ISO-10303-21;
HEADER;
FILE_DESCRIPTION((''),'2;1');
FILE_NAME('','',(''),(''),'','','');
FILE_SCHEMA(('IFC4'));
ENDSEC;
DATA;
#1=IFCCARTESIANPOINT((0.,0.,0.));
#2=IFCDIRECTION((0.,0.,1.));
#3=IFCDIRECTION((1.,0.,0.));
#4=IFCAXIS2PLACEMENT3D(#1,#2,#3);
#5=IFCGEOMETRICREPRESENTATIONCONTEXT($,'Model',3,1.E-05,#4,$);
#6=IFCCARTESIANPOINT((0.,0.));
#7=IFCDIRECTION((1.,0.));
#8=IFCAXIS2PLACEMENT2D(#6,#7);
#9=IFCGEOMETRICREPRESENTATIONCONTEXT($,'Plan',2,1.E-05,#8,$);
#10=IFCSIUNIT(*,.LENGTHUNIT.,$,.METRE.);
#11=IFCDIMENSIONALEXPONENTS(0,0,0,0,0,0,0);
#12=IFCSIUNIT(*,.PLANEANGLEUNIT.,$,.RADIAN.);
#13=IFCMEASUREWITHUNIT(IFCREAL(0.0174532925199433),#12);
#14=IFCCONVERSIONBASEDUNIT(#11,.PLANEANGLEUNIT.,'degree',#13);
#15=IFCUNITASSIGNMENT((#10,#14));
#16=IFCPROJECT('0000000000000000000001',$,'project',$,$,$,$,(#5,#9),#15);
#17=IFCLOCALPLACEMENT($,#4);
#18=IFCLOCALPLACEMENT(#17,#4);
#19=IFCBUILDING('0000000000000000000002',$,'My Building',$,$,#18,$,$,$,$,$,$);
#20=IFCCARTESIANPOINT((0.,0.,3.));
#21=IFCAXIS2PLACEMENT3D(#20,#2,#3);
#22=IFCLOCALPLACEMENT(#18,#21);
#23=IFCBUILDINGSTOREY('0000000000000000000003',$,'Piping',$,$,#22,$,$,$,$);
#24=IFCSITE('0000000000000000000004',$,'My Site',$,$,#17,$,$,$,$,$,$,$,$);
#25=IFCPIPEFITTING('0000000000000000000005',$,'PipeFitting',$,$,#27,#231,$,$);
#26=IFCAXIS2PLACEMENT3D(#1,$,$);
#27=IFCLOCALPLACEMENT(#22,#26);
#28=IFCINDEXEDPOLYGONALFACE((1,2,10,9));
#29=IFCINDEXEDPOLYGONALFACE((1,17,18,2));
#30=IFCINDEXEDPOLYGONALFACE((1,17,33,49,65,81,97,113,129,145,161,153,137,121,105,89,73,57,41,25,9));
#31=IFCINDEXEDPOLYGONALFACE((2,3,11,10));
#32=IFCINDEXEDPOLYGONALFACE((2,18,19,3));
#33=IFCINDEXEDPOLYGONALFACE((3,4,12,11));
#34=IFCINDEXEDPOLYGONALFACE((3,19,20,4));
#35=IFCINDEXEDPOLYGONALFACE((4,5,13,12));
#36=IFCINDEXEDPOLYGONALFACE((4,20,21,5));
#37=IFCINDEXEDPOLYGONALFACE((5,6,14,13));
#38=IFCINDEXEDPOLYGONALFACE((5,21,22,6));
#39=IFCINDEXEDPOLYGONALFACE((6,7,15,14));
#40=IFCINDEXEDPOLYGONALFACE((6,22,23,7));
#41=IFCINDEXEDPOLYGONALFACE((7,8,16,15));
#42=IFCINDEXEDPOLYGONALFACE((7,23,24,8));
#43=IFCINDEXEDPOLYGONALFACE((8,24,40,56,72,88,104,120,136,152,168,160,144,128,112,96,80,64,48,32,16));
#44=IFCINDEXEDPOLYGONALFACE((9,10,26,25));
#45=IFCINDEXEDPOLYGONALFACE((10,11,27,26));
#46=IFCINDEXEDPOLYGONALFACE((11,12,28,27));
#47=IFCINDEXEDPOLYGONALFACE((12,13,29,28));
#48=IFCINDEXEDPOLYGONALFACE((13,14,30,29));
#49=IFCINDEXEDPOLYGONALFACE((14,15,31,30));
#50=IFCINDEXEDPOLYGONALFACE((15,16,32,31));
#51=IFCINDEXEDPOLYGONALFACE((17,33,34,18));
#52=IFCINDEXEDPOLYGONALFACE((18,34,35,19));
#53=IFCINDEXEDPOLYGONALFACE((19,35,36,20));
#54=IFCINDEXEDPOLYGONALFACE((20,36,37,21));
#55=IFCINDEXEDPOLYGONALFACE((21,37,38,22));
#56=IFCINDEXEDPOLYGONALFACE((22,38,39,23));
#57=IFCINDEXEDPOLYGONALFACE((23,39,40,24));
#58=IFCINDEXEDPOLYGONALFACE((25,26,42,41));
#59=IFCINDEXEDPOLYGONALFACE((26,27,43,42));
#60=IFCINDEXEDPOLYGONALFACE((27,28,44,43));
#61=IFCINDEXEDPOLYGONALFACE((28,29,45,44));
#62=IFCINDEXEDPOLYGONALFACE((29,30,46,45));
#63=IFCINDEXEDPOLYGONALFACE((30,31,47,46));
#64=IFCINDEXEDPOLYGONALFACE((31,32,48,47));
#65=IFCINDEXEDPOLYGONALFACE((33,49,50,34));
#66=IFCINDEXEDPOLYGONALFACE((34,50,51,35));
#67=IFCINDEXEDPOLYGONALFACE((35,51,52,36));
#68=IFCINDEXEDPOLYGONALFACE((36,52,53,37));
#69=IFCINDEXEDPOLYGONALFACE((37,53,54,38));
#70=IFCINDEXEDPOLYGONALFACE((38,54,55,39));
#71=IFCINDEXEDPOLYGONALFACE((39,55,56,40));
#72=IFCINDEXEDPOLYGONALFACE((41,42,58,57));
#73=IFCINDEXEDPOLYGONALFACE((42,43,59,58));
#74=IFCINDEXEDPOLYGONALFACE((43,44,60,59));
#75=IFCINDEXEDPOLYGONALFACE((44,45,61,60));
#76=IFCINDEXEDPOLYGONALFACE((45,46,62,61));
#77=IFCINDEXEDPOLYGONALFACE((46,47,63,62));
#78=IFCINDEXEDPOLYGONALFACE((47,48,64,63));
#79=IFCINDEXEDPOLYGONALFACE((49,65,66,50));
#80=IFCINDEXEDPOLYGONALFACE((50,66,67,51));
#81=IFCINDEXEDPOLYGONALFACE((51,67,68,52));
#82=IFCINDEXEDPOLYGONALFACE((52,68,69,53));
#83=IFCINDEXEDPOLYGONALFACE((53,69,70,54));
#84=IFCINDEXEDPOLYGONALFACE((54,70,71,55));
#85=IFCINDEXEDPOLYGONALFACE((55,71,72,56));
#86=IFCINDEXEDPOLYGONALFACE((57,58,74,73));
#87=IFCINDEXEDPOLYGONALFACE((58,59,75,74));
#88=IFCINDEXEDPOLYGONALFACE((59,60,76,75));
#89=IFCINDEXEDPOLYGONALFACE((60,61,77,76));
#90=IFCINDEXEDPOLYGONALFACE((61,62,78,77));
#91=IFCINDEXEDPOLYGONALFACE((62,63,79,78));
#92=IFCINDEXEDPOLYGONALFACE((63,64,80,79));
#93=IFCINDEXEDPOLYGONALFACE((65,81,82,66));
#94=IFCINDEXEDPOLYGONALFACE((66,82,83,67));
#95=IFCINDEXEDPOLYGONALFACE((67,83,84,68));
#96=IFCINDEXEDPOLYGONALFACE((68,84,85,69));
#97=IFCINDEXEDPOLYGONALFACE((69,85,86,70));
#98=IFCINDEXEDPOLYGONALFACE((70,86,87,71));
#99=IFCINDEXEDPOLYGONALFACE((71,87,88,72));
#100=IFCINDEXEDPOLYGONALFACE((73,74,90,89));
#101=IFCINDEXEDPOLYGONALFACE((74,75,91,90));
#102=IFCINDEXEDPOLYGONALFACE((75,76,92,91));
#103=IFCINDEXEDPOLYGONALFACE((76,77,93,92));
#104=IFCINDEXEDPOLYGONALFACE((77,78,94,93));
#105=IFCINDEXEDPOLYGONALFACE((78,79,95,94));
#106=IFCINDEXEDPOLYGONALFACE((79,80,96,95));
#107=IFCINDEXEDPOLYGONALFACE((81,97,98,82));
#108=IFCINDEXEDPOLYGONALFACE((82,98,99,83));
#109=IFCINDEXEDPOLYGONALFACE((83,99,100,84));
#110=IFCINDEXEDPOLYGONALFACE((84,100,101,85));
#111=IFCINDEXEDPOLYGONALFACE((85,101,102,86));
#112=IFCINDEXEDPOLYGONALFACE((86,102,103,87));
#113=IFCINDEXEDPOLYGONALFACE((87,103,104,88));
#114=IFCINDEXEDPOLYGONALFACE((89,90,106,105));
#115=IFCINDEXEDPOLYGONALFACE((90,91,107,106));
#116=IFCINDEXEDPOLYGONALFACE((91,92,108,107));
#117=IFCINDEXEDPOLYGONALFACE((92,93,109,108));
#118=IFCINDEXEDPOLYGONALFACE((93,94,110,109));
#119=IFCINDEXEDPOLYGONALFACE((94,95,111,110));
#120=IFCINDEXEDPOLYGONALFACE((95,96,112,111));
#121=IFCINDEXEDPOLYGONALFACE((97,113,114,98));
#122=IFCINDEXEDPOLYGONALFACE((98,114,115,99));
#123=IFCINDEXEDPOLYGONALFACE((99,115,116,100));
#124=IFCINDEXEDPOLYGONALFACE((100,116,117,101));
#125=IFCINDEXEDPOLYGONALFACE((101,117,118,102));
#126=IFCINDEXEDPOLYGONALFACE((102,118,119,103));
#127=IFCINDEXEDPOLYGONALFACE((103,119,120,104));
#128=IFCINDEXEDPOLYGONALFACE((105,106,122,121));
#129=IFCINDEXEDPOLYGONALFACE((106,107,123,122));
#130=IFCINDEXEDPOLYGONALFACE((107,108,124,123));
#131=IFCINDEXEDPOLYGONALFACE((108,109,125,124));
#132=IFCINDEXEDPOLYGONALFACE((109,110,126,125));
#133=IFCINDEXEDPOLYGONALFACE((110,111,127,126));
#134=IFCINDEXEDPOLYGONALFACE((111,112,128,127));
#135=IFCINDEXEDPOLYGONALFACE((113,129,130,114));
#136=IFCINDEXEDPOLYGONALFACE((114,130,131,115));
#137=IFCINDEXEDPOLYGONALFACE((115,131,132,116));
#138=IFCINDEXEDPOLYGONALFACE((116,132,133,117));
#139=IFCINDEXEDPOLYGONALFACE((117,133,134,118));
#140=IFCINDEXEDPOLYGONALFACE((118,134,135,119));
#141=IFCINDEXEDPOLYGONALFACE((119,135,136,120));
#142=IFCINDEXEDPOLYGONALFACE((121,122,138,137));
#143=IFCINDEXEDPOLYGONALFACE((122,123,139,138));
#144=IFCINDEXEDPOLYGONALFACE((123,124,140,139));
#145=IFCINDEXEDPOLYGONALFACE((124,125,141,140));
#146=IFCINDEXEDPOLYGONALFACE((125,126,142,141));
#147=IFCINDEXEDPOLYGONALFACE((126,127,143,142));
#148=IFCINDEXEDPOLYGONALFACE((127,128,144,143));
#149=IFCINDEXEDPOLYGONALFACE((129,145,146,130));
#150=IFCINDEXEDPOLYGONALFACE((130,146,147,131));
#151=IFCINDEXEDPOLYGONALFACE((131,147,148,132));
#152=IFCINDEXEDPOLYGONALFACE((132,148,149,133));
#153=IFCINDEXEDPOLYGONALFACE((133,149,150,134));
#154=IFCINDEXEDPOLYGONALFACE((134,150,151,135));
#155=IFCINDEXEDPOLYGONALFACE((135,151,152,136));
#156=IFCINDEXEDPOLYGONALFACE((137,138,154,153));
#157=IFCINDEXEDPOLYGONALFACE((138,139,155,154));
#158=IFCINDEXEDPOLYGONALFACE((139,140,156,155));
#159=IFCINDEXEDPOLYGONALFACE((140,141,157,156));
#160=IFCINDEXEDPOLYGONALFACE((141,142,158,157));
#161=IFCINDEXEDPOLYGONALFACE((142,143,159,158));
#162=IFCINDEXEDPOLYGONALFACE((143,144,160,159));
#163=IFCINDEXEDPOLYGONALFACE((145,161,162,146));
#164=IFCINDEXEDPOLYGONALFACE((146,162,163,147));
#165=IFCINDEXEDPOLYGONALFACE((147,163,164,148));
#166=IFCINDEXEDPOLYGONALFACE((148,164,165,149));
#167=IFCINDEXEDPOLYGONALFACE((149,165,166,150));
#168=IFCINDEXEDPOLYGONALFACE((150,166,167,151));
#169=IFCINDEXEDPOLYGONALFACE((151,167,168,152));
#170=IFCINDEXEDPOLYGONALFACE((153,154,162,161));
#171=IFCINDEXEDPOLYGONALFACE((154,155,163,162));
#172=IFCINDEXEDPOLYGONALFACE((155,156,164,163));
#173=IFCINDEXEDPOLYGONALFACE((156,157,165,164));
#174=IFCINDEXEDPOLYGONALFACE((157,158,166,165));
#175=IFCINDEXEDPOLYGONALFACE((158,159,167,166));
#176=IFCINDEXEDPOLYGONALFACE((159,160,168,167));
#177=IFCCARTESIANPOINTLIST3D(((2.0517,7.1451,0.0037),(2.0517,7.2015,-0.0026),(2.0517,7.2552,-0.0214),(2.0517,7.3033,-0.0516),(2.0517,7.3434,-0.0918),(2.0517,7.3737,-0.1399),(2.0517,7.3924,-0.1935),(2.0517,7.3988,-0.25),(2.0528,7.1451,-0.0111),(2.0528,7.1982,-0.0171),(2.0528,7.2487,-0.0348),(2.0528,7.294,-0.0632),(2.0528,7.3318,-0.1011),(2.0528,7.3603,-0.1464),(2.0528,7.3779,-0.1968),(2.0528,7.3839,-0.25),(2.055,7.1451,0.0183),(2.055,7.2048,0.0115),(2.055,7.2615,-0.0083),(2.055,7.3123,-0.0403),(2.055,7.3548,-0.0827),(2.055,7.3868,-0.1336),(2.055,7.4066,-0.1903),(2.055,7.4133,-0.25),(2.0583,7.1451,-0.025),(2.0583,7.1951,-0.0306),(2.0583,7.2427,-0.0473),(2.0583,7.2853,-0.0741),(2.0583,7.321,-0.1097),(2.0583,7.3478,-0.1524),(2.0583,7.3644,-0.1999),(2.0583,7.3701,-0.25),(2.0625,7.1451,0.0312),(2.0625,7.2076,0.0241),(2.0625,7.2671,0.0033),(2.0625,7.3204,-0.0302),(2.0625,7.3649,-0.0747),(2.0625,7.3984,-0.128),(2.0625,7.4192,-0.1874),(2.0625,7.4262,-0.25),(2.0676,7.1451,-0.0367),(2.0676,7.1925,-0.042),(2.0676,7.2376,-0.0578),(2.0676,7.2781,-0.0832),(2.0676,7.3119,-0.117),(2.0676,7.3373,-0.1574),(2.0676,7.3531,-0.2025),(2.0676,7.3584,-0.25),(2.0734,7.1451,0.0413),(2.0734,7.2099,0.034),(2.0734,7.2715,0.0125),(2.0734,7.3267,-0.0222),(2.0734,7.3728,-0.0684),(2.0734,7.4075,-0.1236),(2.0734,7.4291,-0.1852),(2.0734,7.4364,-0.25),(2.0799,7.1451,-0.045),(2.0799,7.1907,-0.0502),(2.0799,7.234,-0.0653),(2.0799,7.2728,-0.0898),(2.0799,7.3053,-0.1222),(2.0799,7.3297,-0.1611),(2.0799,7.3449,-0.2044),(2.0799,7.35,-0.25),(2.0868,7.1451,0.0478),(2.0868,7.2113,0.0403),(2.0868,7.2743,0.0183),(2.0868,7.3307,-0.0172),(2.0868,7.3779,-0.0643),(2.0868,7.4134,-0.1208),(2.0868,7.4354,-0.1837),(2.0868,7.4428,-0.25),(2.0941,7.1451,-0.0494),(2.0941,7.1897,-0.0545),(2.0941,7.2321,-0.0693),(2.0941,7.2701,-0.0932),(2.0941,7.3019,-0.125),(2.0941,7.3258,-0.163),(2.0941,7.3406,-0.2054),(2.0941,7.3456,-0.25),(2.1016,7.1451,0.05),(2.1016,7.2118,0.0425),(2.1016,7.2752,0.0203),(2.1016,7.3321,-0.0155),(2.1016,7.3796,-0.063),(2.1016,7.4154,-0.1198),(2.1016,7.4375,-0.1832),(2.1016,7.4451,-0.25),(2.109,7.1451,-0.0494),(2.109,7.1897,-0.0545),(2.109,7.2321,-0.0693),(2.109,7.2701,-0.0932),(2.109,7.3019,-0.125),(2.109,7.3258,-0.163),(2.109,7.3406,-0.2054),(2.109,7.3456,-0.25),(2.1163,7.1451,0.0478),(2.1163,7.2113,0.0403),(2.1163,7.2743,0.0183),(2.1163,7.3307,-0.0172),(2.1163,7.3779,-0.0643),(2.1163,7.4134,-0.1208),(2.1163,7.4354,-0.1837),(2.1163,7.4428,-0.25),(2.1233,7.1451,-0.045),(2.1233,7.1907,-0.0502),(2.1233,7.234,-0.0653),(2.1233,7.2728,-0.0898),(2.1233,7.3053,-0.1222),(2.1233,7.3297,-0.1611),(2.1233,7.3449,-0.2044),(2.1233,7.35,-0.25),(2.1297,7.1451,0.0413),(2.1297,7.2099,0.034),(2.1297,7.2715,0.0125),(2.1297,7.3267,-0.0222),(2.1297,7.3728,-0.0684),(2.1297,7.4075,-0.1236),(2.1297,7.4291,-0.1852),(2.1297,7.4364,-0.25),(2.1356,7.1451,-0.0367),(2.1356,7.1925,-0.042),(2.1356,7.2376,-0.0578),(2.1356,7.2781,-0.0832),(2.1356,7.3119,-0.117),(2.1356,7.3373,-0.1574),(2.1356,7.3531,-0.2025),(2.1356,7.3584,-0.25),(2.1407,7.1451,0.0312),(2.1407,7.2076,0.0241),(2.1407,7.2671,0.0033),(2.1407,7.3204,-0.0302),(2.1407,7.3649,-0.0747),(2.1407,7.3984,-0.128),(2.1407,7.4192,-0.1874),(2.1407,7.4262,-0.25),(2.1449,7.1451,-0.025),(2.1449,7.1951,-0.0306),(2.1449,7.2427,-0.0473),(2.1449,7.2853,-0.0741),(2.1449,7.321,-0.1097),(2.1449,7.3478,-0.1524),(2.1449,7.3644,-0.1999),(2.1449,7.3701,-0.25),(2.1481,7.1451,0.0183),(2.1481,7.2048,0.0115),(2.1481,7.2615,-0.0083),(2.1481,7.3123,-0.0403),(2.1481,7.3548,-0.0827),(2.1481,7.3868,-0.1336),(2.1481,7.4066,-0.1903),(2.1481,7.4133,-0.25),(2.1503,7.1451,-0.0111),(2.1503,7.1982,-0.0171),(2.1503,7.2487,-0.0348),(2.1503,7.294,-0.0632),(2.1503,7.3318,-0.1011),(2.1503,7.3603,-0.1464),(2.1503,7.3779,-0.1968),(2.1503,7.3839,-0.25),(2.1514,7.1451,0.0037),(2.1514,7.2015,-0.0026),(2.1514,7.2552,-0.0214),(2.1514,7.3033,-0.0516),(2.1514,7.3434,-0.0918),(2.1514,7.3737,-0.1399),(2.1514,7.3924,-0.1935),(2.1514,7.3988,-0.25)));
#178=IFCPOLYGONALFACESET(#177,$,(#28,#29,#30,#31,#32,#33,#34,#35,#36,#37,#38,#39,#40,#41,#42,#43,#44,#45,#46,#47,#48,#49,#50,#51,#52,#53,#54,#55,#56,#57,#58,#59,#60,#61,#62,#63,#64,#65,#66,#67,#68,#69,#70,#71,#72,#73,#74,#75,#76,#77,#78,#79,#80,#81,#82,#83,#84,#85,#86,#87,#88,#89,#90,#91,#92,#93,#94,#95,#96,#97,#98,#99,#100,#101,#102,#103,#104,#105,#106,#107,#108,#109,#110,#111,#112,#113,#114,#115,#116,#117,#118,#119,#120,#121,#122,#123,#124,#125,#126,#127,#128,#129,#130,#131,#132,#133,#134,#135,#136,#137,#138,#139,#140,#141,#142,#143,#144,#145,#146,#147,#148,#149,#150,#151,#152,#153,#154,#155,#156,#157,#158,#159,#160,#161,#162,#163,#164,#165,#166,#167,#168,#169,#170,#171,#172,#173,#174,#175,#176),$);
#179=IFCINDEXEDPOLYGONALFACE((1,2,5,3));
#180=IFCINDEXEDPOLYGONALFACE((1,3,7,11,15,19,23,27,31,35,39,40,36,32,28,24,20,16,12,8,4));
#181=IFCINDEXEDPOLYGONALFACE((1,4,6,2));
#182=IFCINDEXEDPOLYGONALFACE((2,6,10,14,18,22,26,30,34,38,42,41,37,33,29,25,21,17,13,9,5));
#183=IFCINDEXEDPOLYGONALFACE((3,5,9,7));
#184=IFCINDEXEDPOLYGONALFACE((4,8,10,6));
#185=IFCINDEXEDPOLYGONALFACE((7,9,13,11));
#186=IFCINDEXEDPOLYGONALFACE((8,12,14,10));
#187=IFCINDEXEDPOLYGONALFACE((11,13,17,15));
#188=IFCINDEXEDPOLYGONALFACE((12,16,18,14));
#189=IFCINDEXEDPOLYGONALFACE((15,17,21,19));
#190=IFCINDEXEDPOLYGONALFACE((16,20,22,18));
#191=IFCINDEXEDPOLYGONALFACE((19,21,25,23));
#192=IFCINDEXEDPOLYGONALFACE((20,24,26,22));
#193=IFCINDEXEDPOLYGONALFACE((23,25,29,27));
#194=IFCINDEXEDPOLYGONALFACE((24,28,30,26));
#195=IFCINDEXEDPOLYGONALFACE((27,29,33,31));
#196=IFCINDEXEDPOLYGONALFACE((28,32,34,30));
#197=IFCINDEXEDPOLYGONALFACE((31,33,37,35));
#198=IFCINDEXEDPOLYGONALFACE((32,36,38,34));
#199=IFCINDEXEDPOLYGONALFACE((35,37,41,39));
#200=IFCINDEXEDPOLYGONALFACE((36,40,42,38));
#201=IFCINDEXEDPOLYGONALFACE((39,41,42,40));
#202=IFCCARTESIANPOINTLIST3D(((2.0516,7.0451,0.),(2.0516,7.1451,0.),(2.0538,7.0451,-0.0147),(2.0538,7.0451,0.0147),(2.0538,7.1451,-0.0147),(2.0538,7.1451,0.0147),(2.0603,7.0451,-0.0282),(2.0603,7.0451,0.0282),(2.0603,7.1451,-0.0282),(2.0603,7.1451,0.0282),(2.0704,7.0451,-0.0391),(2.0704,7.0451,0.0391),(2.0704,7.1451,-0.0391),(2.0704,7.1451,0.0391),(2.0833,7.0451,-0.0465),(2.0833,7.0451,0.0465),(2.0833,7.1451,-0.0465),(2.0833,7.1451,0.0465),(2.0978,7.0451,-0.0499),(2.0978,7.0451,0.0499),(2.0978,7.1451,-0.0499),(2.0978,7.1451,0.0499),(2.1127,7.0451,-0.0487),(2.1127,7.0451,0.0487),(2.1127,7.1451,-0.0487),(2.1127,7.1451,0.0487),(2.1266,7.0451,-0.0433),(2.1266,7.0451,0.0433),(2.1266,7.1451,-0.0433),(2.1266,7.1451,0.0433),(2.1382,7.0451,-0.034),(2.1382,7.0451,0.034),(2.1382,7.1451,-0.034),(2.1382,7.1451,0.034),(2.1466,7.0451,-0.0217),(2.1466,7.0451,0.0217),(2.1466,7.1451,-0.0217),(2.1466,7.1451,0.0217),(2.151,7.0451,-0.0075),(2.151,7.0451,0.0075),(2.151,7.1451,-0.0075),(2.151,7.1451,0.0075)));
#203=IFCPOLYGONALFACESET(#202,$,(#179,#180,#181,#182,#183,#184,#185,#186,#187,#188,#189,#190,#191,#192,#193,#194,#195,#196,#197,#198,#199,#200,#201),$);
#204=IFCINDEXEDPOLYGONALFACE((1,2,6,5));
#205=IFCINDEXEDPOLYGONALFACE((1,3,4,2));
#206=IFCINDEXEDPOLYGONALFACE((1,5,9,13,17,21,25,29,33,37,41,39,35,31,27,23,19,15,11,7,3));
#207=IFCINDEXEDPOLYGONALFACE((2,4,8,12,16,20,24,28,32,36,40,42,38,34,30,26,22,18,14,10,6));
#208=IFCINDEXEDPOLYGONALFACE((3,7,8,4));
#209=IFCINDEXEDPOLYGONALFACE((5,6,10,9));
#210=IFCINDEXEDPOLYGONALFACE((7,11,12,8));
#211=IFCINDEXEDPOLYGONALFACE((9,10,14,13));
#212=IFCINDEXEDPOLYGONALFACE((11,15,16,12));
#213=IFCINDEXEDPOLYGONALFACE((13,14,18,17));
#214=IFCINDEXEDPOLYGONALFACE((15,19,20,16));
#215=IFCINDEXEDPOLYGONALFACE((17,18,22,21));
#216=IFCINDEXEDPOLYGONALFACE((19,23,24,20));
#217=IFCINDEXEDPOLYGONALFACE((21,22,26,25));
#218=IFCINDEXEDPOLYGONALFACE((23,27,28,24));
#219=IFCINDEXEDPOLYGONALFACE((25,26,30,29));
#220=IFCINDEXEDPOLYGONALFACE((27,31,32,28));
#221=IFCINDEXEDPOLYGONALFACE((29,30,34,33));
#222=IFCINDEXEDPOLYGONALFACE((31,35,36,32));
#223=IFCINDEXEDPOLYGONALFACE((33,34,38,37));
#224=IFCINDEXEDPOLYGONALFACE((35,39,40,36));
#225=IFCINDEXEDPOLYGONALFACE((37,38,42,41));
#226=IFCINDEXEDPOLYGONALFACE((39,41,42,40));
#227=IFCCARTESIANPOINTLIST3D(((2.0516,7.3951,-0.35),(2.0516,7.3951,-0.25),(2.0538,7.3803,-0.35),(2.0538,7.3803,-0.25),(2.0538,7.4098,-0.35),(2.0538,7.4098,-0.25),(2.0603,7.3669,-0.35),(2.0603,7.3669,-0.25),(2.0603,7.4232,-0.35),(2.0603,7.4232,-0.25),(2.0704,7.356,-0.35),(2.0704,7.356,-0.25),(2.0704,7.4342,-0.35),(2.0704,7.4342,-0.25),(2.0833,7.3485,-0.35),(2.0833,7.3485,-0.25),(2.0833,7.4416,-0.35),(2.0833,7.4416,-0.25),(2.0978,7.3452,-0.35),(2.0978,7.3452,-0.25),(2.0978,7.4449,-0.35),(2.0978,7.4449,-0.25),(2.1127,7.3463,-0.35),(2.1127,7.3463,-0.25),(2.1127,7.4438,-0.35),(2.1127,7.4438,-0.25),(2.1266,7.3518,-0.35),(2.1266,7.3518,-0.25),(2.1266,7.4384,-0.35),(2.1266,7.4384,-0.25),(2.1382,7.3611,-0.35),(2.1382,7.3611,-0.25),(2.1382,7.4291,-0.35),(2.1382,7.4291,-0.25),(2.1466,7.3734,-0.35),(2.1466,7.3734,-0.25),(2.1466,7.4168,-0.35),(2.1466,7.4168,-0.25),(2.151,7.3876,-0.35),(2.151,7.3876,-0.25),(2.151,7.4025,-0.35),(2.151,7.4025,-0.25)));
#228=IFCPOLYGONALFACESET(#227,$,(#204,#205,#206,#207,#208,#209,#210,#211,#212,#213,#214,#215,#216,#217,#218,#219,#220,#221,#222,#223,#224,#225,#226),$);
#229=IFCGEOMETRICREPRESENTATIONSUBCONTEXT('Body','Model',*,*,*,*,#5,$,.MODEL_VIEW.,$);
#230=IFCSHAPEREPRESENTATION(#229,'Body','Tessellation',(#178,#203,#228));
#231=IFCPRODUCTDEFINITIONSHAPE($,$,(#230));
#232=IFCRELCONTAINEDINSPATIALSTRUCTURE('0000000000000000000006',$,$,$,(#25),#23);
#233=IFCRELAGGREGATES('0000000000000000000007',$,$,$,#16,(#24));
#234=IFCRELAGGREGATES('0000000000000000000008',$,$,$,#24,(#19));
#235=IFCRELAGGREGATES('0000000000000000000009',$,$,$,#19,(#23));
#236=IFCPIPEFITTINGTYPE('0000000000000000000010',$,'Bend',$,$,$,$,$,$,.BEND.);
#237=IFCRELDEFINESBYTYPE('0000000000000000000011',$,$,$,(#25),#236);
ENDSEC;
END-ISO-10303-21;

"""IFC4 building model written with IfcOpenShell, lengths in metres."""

from ifc_helpers import new_model, entity, si_unit, converted_unit, frame, origin_with_axes, origin_2d_with_axis, place, context, subcontext, project, spatial, circle, extrude, source, transform, mapped, type_object, type_shapes, element, save


model = new_model("IFC4")

# Units and contexts
model_context = context("Model", 3, precision=1e-05, world=origin_with_axes())
plan_context = context("Plan", 2, precision=1e-05, world=origin_2d_with_axis())
body_context = subcontext(model_context, "Body", "Model", "MODEL_VIEW")
ifc_project = project(units=[si_unit("LENGTHUNIT", "METRE"), converted_unit("PLANEANGLEUNIT", "degree", entity("IfcReal", 0.0174532925199433), si_unit("PLANEANGLEUNIT", "RADIAN"), dimensions=[0, 0, 0, 0, 0, 0, 0])], contexts=[model_context, plan_context])

# Site, building, storey
site_placement = place(None, origin_with_axes())
site = spatial("IfcSite", under=ifc_project, at=site_placement, Name="My Site")
building_placement = place(site_placement, origin_with_axes())
building = spatial("IfcBuilding", under=site, at=building_placement, Name="My Building")
storey_placement = place(building_placement, frame((0.0, 0.0, 3.0), z_axis=(0.0, 0.0, 1.0), x_axis=(1.0, 0.0, 0.0)))
storey = spatial("IfcBuildingStorey", under=building, at=storey_placement, Name="Piping")

# Pipe fitting
pipe_fitting_type = type_object("IfcPipeFittingType", Name="Bend", PredefinedType="BEND")
shared_shape = source(origin_with_axes(), body_context, "Body", "SolidModel", [
    entity("IfcSweptDiskSolid", entity("IfcIndexedPolyCurve", entity("IfcCartesianPointList3D", [[0.0, 0.0, -0.1], [0.0, 0.0732, -0.2768], [0.0, 0.25, -0.35]]), [entity("IfcArcIndex", [1, 2, 3])]), 0.05),
    extrude(circle(Radius=0.05), origin_with_axes(), (0.0, 0.0, -1.0), 0.1),
    extrude(circle(Radius=0.05), frame((0.0, 0.25, -0.35), z_axis=(0.0, 1.0, 0.0), x_axis=(1.0, 0.0, 0.0)), (0.0, 0.0, 1.0), 0.1),
])
type_shapes(pipe_fitting_type, [shared_shape])
for number, where, z_axis, x_axis, name in (
    (1, (2.1016, 7.0451, 0.0), (0.0, -1.0, 0.0), (-1.0, 0.0, 0.0), "PipeFitting"),
):
    element("IfcPipeFitting", number, at=place(storey_placement, frame(where, z_axis=z_axis, x_axis=x_axis)), inside=storey, type_object=pipe_fitting_type, Name=name, context=body_context, shape_type="MappedRepresentation", body=[
        mapped(shared_shape, transform((0.0, 0.0, 0.0), x_axis=(1.0, 0.0, 0.0), y_axis=(0.0, 1.0, 0.0), z_axis=(0.0, 0.0, 1.0), scale=1.0)),
    ])

save(model, "model.ifc")
